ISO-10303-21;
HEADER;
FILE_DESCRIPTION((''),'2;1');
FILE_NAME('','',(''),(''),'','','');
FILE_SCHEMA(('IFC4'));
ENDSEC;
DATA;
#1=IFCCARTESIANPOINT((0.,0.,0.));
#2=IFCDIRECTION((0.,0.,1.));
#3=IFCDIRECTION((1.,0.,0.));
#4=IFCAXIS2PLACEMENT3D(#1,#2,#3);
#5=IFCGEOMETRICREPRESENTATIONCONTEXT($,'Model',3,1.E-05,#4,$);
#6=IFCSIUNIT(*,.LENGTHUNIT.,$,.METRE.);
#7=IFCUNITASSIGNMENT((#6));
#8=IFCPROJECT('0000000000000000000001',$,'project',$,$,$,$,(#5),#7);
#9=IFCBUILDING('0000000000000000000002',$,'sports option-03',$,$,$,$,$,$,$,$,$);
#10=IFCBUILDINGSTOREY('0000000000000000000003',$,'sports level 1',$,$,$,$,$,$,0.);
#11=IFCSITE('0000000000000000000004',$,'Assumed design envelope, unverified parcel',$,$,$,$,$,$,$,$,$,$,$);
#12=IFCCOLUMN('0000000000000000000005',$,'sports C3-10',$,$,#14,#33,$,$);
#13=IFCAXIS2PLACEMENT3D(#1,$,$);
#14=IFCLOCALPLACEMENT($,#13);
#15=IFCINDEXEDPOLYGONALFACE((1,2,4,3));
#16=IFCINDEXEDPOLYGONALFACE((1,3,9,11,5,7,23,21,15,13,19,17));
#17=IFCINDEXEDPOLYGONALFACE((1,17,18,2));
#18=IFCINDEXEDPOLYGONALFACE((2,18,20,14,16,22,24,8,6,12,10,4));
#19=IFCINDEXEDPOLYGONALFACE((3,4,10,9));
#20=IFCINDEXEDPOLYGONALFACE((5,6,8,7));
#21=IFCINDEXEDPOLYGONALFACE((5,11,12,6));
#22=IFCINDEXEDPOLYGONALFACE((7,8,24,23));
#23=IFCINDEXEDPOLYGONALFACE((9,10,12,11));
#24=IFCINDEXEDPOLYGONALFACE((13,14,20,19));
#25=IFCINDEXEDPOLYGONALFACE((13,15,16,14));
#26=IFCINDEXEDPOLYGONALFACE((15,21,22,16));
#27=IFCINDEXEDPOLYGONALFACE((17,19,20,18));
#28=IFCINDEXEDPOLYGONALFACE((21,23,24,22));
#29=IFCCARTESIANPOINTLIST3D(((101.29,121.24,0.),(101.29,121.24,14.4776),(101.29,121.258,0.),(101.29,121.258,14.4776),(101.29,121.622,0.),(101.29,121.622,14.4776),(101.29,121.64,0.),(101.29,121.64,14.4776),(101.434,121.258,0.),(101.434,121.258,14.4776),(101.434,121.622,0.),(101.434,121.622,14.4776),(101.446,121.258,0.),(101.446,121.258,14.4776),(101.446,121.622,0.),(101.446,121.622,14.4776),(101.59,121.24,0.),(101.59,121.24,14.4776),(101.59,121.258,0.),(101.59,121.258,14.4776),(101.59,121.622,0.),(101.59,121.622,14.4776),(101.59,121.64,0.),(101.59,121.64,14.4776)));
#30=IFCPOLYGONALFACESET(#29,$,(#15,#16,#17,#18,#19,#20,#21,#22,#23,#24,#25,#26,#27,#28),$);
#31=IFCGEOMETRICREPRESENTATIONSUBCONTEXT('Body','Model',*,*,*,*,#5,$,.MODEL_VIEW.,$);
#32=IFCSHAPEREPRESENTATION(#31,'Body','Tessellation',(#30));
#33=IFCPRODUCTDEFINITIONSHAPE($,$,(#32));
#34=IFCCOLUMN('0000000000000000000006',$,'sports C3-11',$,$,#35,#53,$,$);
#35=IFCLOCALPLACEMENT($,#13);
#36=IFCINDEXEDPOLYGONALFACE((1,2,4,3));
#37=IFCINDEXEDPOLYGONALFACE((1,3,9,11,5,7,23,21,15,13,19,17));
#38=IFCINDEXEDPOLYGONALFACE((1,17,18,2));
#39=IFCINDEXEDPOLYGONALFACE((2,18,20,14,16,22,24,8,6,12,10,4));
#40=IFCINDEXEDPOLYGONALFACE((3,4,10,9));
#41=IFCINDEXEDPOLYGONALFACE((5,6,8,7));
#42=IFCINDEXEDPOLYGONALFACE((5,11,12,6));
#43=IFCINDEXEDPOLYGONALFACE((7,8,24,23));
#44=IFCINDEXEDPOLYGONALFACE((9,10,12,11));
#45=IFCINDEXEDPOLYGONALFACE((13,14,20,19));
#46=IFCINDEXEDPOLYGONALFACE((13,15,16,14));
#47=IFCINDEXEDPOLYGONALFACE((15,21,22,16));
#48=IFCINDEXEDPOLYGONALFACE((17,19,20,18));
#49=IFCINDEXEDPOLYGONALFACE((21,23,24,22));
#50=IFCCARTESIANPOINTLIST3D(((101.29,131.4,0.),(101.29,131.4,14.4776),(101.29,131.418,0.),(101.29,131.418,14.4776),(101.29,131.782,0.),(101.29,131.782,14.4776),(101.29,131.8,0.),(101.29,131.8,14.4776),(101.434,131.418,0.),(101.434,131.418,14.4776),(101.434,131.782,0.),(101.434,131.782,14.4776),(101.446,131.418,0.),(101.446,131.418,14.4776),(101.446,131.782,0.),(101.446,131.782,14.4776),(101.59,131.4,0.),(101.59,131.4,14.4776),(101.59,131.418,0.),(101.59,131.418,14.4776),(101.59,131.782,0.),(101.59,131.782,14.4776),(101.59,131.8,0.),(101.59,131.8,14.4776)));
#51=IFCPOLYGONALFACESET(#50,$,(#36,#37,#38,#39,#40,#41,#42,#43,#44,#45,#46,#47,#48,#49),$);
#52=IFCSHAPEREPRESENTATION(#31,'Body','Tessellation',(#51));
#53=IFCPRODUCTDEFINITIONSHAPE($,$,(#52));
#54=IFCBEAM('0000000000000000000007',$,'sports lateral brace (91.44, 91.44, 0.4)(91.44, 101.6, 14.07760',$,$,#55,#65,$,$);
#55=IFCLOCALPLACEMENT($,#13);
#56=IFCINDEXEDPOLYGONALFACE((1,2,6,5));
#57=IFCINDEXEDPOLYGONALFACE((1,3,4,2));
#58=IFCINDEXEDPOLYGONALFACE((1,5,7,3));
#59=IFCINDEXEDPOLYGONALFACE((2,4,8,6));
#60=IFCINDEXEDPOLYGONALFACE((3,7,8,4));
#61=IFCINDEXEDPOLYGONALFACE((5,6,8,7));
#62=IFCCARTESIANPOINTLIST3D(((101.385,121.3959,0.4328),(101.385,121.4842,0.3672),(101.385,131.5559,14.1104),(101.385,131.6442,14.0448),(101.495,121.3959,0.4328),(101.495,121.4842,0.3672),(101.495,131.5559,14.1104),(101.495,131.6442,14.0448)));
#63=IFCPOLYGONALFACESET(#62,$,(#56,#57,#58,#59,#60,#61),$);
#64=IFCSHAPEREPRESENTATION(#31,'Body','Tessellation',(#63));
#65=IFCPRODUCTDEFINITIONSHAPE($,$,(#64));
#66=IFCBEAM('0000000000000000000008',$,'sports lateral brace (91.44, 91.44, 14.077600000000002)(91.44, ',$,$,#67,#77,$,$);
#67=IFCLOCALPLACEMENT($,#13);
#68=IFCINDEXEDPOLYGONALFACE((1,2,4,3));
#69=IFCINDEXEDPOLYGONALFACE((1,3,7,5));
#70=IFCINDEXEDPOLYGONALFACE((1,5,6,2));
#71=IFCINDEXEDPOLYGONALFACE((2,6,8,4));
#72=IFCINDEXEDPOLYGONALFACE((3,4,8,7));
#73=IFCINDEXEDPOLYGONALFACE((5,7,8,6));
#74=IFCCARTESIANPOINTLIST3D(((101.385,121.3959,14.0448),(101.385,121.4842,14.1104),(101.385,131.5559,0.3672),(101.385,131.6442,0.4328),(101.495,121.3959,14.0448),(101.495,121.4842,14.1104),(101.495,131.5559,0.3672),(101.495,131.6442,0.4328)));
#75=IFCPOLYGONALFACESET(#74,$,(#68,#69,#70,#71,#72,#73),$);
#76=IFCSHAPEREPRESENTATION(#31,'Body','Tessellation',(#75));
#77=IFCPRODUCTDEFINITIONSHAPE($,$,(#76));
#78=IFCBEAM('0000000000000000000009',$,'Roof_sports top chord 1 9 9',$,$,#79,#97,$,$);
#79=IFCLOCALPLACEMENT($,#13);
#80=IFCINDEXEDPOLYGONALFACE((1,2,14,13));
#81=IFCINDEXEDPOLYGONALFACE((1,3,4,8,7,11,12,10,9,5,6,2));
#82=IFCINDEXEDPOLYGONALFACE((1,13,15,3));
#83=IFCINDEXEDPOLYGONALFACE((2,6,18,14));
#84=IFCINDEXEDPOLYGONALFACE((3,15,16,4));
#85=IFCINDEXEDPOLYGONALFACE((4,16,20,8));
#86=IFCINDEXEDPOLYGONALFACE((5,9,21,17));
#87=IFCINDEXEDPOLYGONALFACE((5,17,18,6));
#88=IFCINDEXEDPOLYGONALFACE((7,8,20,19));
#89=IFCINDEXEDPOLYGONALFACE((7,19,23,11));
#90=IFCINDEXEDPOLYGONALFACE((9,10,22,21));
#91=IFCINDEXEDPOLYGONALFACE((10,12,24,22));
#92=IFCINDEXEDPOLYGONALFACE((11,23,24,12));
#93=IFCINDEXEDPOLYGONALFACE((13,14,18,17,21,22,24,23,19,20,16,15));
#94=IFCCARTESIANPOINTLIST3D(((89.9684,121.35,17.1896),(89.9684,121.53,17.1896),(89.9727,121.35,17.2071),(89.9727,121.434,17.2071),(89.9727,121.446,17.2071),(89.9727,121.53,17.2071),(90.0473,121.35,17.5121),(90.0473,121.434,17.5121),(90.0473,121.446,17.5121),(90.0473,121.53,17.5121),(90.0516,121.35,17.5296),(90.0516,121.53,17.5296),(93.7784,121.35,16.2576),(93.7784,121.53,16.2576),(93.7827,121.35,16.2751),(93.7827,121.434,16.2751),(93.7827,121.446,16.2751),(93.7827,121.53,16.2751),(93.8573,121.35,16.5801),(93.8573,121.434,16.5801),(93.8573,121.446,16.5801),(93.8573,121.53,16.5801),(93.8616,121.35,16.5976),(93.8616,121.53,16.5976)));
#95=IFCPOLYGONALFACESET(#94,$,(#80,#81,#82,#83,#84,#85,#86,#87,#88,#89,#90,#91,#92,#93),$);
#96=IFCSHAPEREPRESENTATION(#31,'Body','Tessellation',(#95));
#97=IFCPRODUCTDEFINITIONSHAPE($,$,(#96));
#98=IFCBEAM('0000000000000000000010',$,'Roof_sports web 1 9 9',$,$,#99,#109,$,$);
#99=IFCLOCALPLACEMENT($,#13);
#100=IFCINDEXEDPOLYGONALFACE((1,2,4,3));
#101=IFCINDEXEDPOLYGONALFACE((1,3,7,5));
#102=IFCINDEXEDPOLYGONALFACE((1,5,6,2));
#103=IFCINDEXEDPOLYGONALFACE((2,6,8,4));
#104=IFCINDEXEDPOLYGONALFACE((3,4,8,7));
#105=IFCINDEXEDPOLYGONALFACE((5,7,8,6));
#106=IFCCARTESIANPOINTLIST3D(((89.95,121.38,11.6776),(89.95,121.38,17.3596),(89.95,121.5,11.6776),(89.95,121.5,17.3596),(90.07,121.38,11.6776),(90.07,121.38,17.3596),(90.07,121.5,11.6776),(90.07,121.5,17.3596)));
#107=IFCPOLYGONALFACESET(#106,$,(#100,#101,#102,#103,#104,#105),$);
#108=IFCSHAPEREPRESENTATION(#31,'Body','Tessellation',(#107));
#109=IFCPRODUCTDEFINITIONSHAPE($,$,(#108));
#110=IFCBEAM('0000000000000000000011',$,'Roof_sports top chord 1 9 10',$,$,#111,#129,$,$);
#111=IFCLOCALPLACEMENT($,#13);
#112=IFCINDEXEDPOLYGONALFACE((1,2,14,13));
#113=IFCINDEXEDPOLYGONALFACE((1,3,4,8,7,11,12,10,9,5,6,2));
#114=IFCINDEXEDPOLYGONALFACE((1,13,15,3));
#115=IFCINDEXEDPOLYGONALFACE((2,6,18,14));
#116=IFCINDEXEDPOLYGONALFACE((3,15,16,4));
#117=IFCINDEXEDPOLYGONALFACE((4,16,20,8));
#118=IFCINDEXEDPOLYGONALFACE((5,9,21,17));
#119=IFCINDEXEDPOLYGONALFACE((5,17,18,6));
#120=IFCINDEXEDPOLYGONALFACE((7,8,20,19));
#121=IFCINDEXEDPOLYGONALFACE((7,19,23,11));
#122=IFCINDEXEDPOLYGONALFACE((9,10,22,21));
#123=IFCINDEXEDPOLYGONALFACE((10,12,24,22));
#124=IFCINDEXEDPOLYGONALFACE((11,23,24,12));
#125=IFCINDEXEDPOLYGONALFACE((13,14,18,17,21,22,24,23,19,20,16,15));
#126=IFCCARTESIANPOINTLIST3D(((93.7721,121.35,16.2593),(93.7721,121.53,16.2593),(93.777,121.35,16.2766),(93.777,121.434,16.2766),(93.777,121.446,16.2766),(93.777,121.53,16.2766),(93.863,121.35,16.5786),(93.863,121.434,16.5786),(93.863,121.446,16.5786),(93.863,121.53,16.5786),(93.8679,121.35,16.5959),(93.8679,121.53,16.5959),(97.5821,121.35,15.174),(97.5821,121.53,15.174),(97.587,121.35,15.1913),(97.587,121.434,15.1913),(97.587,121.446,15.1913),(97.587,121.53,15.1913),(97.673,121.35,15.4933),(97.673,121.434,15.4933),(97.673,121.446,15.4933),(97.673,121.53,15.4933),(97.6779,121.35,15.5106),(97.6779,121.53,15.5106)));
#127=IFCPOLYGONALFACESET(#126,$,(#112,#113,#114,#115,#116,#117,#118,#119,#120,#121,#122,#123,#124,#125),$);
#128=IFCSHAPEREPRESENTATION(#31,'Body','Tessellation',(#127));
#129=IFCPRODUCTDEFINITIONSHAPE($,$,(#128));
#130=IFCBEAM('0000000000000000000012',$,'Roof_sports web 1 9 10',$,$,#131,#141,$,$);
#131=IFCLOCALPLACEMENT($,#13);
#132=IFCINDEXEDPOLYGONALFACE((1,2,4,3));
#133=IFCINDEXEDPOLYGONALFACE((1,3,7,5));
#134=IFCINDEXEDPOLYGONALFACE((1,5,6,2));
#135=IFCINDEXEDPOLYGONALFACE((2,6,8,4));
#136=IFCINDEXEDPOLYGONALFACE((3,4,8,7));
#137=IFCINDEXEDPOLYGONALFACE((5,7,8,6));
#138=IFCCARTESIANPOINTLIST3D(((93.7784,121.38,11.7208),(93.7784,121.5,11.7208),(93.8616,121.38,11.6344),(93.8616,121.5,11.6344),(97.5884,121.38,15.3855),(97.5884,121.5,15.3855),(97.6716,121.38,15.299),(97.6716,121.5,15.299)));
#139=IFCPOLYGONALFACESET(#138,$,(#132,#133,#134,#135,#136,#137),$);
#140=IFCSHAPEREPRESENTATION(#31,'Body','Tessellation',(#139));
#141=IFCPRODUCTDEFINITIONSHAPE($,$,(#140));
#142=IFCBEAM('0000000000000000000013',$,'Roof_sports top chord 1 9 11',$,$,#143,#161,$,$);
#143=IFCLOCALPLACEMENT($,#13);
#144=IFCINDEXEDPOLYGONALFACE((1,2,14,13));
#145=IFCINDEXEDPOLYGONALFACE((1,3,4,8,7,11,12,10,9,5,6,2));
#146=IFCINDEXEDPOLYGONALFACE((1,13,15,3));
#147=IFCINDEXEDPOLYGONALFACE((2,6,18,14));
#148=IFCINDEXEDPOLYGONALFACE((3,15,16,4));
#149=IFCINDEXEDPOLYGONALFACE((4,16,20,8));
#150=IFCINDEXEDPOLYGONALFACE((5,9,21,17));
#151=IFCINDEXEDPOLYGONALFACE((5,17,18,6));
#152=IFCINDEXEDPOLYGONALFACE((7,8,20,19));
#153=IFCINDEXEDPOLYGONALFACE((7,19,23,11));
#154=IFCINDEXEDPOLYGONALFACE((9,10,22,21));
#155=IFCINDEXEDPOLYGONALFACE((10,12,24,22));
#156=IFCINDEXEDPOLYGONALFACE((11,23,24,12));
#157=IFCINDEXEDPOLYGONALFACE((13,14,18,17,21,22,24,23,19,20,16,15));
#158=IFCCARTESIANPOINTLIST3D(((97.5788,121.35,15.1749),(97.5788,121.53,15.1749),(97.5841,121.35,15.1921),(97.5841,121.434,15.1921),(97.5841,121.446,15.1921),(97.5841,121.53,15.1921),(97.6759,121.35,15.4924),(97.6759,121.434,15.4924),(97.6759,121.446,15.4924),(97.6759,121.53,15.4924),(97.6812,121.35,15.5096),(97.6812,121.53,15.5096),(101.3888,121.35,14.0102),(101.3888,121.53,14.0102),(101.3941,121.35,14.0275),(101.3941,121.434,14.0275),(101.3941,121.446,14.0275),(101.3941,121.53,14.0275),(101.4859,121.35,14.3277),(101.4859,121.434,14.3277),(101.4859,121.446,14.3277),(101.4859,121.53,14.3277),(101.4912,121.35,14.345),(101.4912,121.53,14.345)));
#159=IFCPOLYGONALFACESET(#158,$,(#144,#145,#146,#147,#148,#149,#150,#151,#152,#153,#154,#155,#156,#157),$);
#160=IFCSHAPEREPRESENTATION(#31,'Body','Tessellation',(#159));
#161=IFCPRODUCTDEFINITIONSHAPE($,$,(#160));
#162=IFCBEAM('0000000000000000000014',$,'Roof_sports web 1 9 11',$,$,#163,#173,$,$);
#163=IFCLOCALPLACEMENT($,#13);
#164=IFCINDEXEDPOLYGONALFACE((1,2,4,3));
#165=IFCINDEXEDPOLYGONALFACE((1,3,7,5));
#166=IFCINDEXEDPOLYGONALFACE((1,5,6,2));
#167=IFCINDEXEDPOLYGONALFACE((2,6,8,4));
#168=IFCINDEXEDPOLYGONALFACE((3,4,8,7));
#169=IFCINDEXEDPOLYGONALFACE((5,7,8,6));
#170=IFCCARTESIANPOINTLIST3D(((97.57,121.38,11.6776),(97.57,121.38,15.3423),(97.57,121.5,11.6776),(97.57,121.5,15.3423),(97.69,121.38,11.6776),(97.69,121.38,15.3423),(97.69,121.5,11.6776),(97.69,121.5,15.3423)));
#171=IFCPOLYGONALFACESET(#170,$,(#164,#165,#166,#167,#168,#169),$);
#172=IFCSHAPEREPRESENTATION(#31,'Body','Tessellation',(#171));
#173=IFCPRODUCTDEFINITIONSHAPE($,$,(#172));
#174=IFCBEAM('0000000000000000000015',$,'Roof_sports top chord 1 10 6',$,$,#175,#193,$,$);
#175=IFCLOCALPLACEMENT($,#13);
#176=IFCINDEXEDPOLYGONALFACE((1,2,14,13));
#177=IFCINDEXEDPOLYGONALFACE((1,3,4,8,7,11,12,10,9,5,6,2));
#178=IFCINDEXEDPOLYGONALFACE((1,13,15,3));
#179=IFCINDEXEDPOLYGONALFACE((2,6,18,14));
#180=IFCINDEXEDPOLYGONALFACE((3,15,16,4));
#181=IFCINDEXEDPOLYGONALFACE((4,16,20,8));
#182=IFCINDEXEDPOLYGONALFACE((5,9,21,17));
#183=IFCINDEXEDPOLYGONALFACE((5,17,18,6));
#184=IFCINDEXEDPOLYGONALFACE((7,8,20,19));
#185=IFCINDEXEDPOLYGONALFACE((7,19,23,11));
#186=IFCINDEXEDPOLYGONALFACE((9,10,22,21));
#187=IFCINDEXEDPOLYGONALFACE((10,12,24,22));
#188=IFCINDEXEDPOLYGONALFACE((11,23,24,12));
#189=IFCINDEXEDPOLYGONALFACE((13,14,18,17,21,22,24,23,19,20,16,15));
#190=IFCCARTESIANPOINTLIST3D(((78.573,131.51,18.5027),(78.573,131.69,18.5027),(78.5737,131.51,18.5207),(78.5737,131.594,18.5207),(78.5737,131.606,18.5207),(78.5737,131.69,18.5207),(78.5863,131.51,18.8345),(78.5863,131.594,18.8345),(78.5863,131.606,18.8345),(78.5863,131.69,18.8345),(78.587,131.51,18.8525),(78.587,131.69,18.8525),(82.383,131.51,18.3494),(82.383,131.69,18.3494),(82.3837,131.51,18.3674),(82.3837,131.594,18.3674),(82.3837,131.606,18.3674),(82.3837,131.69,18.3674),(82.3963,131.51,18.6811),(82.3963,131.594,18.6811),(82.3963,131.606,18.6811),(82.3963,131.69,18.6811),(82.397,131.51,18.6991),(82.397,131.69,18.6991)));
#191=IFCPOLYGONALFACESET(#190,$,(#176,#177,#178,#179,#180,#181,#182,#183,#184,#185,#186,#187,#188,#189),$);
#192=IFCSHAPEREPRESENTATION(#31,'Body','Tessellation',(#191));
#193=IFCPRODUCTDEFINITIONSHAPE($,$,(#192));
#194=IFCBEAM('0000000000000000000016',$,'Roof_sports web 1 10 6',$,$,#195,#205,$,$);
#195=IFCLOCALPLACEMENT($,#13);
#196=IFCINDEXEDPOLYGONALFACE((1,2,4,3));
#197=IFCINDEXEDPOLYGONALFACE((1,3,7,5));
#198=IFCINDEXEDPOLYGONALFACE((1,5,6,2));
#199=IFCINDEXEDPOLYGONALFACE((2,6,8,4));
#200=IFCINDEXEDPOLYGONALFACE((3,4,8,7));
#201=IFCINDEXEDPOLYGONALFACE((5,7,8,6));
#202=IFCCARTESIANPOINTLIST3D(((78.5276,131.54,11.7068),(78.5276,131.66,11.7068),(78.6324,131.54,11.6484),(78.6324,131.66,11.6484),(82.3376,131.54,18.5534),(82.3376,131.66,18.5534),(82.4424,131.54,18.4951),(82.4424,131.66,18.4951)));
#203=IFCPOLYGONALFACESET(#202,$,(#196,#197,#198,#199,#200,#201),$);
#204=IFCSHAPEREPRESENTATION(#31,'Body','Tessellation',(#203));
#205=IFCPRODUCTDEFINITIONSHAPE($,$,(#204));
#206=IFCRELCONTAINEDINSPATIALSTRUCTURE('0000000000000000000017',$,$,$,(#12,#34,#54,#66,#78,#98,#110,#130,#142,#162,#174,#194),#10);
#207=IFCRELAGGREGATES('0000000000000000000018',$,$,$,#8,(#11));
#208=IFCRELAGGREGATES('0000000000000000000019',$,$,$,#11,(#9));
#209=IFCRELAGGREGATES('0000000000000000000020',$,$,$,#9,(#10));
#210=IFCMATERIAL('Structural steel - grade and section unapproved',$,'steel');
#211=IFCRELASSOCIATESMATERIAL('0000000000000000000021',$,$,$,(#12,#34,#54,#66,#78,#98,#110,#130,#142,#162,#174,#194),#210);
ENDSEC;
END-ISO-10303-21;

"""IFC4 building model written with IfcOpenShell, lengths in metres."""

from ifc_helpers import new_model, si_unit, frame, origin_with_axes, place, context, subcontext, project, spatial, rectangle, i_section, extrude, material, element, save


model = new_model("IFC4")

# Units and contexts
model_context = context("Model", 3, precision=1e-05, world=origin_with_axes())
body_context = subcontext(model_context, "Body", "Model", "MODEL_VIEW")
ifc_project = project(units=[si_unit("LENGTHUNIT", "METRE")], contexts=[model_context])

# Site, building, storey
site = spatial("IfcSite", under=ifc_project, Name="Assumed design envelope, unverified parcel")
building = spatial("IfcBuilding", under=site, Name="sports option-03")
storey = spatial("IfcBuildingStorey", under=building, Name="sports level 1", Elevation=0.0)

# Columns
ifc_material_1 = material(Name="Structural steel - grade and section unapproved", Category="steel")
for number, where, z_axis, x_axis, name in (
    (1, (101.44, 121.44, 0.0), (0.0, 0.0, 1.0), (-1.0, 0.0, 0.0), "sports C3-10"),
    (2, (101.44, 131.6, 0.0), (0.0, 0.0, 1.0), (-1.0, 0.0, 0.0), "sports C3-11"),
):
    element("IfcColumn", number, at=place(None, frame(where, z_axis=z_axis, x_axis=x_axis)), inside=storey, material=ifc_material_1, Name=name, context=body_context, shape_type="SweptSolid", body=[
        extrude(i_section(OverallWidth=0.3, OverallDepth=0.4, WebThickness=0.012, FlangeThickness=0.018, FilletRadius=0.0), origin_with_axes(), (0.0, 0.0, 1.0), 14.4776),
    ])

# Beams
for number, where, z_axis, x_axis, name in (
    (3, (101.44, 121.44, 0.4), (0.0, 0.596305, 0.802758), (-1.0, 0.0, 0.0), "sports lateral brace (91.44, 91.44, 0.4)(91.44, 101.6, 14.07760"),
    (4, (101.44, 121.44, 14.0776), (0.0, 0.596305, -0.802758), (-1.0, 0.0, 0.0), "sports lateral brace (91.44, 91.44, 14.077600000000002)(91.44, "),
):
    element("IfcBeam", number, at=place(None, frame(where, z_axis=z_axis, x_axis=x_axis)), inside=storey, material=ifc_material_1, Name=name, context=body_context, shape_type="SweptSolid", body=[
        extrude(rectangle(XDim=0.11, YDim=0.11), origin_with_axes(), (0.0, 0.0, 1.0), 17.0383),
    ])
beam_1_placement = place(None, frame((90.01, 121.44, 17.3596), z_axis=(0.971361, 0.0, -0.237609), x_axis=(0.0, 1.0, 0.0)))
element("IfcBeam", 5, at=beam_1_placement, inside=storey, material=ifc_material_1, Name="Roof_sports top chord 1 9 9", context=body_context, shape_type="SweptSolid", body=[
    extrude(i_section(OverallWidth=0.18, OverallDepth=0.35, WebThickness=0.012, FlangeThickness=0.018, FilletRadius=0.0), origin_with_axes(), (0.0, 0.0, 1.0), 3.9223),
])
beam_2_placement = place(None, frame((90.01, 121.44, 11.6776), z_axis=(0.0, 0.0, 1.0), x_axis=(-1.0, 0.0, 0.0)))
element("IfcBeam", 6, at=beam_2_placement, inside=storey, material=ifc_material_1, Name="Roof_sports web 1 9 9", context=body_context, shape_type="SweptSolid", body=[
    extrude(rectangle(XDim=0.12, YDim=0.12), origin_with_axes(), (0.0, 0.0, 1.0), 5.682),
])
beam_3_placement = place(None, frame((93.82, 121.44, 16.4276), z_axis=(0.961741, 0.0, -0.273961), x_axis=(0.0, 1.0, 0.0)))
element("IfcBeam", 7, at=beam_3_placement, inside=storey, material=ifc_material_1, Name="Roof_sports top chord 1 9 10", context=body_context, shape_type="SweptSolid", body=[
    extrude(i_section(OverallWidth=0.18, OverallDepth=0.35, WebThickness=0.012, FlangeThickness=0.018, FilletRadius=0.0), origin_with_axes(), (0.0, 0.0, 1.0), 3.9616),
])
beam_4_placement = place(None, frame((93.82, 121.44, 11.6776), z_axis=(0.720717, 0.0, 0.693229), x_axis=(0.0, 1.0, 0.0)))
element("IfcBeam", 8, at=beam_4_placement, inside=storey, material=ifc_material_1, Name="Roof_sports web 1 9 10", context=body_context, shape_type="SweptSolid", body=[
    extrude(rectangle(XDim=0.12, YDim=0.12), origin_with_axes(), (0.0, 0.0, 1.0), 5.2864),
])
beam_5_placement = place(None, frame((97.63, 121.44, 15.3423), z_axis=(0.956315, 0.0, -0.292337), x_axis=(0.0, 1.0, 0.0)))
element("IfcBeam", 9, at=beam_5_placement, inside=storey, material=ifc_material_1, Name="Roof_sports top chord 1 9 11", context=body_context, shape_type="SweptSolid", body=[
    extrude(i_section(OverallWidth=0.18, OverallDepth=0.35, WebThickness=0.012, FlangeThickness=0.018, FilletRadius=0.0), origin_with_axes(), (0.0, 0.0, 1.0), 3.984),
])
beam_6_placement = place(None, frame((97.63, 121.44, 11.6776), z_axis=(0.0, 0.0, 1.0), x_axis=(-1.0, 0.0, 0.0)))
element("IfcBeam", 10, at=beam_6_placement, inside=storey, material=ifc_material_1, Name="Roof_sports web 1 9 11", context=body_context, shape_type="SweptSolid", body=[
    extrude(rectangle(XDim=0.12, YDim=0.12), origin_with_axes(), (0.0, 0.0, 1.0), 3.6647),
])
beam_7_placement = place(None, frame((78.58, 131.6, 18.6776), z_axis=(0.999191, 0.0, -0.040212), x_axis=(0.0, 1.0, 0.0)))
element("IfcBeam", 11, at=beam_7_placement, inside=storey, material=ifc_material_1, Name="Roof_sports top chord 1 10 6", context=body_context, shape_type="SweptSolid", body=[
    extrude(i_section(OverallWidth=0.18, OverallDepth=0.35, WebThickness=0.012, FlangeThickness=0.018, FilletRadius=0.0), origin_with_axes(), (0.0, 0.0, 1.0), 3.8131),
])
beam_8_placement = place(None, frame((78.58, 131.6, 11.6776), z_axis=(0.486257, 0.0, 0.873816), x_axis=(0.0, 1.0, 0.0)))
element("IfcBeam", 12, at=beam_8_placement, inside=storey, material=ifc_material_1, Name="Roof_sports web 1 10 6", context=body_context, shape_type="SweptSolid", body=[
    extrude(rectangle(XDim=0.12, YDim=0.12), origin_with_axes(), (0.0, 0.0, 1.0), 7.8354),
])

save(model, "model.ifc")
